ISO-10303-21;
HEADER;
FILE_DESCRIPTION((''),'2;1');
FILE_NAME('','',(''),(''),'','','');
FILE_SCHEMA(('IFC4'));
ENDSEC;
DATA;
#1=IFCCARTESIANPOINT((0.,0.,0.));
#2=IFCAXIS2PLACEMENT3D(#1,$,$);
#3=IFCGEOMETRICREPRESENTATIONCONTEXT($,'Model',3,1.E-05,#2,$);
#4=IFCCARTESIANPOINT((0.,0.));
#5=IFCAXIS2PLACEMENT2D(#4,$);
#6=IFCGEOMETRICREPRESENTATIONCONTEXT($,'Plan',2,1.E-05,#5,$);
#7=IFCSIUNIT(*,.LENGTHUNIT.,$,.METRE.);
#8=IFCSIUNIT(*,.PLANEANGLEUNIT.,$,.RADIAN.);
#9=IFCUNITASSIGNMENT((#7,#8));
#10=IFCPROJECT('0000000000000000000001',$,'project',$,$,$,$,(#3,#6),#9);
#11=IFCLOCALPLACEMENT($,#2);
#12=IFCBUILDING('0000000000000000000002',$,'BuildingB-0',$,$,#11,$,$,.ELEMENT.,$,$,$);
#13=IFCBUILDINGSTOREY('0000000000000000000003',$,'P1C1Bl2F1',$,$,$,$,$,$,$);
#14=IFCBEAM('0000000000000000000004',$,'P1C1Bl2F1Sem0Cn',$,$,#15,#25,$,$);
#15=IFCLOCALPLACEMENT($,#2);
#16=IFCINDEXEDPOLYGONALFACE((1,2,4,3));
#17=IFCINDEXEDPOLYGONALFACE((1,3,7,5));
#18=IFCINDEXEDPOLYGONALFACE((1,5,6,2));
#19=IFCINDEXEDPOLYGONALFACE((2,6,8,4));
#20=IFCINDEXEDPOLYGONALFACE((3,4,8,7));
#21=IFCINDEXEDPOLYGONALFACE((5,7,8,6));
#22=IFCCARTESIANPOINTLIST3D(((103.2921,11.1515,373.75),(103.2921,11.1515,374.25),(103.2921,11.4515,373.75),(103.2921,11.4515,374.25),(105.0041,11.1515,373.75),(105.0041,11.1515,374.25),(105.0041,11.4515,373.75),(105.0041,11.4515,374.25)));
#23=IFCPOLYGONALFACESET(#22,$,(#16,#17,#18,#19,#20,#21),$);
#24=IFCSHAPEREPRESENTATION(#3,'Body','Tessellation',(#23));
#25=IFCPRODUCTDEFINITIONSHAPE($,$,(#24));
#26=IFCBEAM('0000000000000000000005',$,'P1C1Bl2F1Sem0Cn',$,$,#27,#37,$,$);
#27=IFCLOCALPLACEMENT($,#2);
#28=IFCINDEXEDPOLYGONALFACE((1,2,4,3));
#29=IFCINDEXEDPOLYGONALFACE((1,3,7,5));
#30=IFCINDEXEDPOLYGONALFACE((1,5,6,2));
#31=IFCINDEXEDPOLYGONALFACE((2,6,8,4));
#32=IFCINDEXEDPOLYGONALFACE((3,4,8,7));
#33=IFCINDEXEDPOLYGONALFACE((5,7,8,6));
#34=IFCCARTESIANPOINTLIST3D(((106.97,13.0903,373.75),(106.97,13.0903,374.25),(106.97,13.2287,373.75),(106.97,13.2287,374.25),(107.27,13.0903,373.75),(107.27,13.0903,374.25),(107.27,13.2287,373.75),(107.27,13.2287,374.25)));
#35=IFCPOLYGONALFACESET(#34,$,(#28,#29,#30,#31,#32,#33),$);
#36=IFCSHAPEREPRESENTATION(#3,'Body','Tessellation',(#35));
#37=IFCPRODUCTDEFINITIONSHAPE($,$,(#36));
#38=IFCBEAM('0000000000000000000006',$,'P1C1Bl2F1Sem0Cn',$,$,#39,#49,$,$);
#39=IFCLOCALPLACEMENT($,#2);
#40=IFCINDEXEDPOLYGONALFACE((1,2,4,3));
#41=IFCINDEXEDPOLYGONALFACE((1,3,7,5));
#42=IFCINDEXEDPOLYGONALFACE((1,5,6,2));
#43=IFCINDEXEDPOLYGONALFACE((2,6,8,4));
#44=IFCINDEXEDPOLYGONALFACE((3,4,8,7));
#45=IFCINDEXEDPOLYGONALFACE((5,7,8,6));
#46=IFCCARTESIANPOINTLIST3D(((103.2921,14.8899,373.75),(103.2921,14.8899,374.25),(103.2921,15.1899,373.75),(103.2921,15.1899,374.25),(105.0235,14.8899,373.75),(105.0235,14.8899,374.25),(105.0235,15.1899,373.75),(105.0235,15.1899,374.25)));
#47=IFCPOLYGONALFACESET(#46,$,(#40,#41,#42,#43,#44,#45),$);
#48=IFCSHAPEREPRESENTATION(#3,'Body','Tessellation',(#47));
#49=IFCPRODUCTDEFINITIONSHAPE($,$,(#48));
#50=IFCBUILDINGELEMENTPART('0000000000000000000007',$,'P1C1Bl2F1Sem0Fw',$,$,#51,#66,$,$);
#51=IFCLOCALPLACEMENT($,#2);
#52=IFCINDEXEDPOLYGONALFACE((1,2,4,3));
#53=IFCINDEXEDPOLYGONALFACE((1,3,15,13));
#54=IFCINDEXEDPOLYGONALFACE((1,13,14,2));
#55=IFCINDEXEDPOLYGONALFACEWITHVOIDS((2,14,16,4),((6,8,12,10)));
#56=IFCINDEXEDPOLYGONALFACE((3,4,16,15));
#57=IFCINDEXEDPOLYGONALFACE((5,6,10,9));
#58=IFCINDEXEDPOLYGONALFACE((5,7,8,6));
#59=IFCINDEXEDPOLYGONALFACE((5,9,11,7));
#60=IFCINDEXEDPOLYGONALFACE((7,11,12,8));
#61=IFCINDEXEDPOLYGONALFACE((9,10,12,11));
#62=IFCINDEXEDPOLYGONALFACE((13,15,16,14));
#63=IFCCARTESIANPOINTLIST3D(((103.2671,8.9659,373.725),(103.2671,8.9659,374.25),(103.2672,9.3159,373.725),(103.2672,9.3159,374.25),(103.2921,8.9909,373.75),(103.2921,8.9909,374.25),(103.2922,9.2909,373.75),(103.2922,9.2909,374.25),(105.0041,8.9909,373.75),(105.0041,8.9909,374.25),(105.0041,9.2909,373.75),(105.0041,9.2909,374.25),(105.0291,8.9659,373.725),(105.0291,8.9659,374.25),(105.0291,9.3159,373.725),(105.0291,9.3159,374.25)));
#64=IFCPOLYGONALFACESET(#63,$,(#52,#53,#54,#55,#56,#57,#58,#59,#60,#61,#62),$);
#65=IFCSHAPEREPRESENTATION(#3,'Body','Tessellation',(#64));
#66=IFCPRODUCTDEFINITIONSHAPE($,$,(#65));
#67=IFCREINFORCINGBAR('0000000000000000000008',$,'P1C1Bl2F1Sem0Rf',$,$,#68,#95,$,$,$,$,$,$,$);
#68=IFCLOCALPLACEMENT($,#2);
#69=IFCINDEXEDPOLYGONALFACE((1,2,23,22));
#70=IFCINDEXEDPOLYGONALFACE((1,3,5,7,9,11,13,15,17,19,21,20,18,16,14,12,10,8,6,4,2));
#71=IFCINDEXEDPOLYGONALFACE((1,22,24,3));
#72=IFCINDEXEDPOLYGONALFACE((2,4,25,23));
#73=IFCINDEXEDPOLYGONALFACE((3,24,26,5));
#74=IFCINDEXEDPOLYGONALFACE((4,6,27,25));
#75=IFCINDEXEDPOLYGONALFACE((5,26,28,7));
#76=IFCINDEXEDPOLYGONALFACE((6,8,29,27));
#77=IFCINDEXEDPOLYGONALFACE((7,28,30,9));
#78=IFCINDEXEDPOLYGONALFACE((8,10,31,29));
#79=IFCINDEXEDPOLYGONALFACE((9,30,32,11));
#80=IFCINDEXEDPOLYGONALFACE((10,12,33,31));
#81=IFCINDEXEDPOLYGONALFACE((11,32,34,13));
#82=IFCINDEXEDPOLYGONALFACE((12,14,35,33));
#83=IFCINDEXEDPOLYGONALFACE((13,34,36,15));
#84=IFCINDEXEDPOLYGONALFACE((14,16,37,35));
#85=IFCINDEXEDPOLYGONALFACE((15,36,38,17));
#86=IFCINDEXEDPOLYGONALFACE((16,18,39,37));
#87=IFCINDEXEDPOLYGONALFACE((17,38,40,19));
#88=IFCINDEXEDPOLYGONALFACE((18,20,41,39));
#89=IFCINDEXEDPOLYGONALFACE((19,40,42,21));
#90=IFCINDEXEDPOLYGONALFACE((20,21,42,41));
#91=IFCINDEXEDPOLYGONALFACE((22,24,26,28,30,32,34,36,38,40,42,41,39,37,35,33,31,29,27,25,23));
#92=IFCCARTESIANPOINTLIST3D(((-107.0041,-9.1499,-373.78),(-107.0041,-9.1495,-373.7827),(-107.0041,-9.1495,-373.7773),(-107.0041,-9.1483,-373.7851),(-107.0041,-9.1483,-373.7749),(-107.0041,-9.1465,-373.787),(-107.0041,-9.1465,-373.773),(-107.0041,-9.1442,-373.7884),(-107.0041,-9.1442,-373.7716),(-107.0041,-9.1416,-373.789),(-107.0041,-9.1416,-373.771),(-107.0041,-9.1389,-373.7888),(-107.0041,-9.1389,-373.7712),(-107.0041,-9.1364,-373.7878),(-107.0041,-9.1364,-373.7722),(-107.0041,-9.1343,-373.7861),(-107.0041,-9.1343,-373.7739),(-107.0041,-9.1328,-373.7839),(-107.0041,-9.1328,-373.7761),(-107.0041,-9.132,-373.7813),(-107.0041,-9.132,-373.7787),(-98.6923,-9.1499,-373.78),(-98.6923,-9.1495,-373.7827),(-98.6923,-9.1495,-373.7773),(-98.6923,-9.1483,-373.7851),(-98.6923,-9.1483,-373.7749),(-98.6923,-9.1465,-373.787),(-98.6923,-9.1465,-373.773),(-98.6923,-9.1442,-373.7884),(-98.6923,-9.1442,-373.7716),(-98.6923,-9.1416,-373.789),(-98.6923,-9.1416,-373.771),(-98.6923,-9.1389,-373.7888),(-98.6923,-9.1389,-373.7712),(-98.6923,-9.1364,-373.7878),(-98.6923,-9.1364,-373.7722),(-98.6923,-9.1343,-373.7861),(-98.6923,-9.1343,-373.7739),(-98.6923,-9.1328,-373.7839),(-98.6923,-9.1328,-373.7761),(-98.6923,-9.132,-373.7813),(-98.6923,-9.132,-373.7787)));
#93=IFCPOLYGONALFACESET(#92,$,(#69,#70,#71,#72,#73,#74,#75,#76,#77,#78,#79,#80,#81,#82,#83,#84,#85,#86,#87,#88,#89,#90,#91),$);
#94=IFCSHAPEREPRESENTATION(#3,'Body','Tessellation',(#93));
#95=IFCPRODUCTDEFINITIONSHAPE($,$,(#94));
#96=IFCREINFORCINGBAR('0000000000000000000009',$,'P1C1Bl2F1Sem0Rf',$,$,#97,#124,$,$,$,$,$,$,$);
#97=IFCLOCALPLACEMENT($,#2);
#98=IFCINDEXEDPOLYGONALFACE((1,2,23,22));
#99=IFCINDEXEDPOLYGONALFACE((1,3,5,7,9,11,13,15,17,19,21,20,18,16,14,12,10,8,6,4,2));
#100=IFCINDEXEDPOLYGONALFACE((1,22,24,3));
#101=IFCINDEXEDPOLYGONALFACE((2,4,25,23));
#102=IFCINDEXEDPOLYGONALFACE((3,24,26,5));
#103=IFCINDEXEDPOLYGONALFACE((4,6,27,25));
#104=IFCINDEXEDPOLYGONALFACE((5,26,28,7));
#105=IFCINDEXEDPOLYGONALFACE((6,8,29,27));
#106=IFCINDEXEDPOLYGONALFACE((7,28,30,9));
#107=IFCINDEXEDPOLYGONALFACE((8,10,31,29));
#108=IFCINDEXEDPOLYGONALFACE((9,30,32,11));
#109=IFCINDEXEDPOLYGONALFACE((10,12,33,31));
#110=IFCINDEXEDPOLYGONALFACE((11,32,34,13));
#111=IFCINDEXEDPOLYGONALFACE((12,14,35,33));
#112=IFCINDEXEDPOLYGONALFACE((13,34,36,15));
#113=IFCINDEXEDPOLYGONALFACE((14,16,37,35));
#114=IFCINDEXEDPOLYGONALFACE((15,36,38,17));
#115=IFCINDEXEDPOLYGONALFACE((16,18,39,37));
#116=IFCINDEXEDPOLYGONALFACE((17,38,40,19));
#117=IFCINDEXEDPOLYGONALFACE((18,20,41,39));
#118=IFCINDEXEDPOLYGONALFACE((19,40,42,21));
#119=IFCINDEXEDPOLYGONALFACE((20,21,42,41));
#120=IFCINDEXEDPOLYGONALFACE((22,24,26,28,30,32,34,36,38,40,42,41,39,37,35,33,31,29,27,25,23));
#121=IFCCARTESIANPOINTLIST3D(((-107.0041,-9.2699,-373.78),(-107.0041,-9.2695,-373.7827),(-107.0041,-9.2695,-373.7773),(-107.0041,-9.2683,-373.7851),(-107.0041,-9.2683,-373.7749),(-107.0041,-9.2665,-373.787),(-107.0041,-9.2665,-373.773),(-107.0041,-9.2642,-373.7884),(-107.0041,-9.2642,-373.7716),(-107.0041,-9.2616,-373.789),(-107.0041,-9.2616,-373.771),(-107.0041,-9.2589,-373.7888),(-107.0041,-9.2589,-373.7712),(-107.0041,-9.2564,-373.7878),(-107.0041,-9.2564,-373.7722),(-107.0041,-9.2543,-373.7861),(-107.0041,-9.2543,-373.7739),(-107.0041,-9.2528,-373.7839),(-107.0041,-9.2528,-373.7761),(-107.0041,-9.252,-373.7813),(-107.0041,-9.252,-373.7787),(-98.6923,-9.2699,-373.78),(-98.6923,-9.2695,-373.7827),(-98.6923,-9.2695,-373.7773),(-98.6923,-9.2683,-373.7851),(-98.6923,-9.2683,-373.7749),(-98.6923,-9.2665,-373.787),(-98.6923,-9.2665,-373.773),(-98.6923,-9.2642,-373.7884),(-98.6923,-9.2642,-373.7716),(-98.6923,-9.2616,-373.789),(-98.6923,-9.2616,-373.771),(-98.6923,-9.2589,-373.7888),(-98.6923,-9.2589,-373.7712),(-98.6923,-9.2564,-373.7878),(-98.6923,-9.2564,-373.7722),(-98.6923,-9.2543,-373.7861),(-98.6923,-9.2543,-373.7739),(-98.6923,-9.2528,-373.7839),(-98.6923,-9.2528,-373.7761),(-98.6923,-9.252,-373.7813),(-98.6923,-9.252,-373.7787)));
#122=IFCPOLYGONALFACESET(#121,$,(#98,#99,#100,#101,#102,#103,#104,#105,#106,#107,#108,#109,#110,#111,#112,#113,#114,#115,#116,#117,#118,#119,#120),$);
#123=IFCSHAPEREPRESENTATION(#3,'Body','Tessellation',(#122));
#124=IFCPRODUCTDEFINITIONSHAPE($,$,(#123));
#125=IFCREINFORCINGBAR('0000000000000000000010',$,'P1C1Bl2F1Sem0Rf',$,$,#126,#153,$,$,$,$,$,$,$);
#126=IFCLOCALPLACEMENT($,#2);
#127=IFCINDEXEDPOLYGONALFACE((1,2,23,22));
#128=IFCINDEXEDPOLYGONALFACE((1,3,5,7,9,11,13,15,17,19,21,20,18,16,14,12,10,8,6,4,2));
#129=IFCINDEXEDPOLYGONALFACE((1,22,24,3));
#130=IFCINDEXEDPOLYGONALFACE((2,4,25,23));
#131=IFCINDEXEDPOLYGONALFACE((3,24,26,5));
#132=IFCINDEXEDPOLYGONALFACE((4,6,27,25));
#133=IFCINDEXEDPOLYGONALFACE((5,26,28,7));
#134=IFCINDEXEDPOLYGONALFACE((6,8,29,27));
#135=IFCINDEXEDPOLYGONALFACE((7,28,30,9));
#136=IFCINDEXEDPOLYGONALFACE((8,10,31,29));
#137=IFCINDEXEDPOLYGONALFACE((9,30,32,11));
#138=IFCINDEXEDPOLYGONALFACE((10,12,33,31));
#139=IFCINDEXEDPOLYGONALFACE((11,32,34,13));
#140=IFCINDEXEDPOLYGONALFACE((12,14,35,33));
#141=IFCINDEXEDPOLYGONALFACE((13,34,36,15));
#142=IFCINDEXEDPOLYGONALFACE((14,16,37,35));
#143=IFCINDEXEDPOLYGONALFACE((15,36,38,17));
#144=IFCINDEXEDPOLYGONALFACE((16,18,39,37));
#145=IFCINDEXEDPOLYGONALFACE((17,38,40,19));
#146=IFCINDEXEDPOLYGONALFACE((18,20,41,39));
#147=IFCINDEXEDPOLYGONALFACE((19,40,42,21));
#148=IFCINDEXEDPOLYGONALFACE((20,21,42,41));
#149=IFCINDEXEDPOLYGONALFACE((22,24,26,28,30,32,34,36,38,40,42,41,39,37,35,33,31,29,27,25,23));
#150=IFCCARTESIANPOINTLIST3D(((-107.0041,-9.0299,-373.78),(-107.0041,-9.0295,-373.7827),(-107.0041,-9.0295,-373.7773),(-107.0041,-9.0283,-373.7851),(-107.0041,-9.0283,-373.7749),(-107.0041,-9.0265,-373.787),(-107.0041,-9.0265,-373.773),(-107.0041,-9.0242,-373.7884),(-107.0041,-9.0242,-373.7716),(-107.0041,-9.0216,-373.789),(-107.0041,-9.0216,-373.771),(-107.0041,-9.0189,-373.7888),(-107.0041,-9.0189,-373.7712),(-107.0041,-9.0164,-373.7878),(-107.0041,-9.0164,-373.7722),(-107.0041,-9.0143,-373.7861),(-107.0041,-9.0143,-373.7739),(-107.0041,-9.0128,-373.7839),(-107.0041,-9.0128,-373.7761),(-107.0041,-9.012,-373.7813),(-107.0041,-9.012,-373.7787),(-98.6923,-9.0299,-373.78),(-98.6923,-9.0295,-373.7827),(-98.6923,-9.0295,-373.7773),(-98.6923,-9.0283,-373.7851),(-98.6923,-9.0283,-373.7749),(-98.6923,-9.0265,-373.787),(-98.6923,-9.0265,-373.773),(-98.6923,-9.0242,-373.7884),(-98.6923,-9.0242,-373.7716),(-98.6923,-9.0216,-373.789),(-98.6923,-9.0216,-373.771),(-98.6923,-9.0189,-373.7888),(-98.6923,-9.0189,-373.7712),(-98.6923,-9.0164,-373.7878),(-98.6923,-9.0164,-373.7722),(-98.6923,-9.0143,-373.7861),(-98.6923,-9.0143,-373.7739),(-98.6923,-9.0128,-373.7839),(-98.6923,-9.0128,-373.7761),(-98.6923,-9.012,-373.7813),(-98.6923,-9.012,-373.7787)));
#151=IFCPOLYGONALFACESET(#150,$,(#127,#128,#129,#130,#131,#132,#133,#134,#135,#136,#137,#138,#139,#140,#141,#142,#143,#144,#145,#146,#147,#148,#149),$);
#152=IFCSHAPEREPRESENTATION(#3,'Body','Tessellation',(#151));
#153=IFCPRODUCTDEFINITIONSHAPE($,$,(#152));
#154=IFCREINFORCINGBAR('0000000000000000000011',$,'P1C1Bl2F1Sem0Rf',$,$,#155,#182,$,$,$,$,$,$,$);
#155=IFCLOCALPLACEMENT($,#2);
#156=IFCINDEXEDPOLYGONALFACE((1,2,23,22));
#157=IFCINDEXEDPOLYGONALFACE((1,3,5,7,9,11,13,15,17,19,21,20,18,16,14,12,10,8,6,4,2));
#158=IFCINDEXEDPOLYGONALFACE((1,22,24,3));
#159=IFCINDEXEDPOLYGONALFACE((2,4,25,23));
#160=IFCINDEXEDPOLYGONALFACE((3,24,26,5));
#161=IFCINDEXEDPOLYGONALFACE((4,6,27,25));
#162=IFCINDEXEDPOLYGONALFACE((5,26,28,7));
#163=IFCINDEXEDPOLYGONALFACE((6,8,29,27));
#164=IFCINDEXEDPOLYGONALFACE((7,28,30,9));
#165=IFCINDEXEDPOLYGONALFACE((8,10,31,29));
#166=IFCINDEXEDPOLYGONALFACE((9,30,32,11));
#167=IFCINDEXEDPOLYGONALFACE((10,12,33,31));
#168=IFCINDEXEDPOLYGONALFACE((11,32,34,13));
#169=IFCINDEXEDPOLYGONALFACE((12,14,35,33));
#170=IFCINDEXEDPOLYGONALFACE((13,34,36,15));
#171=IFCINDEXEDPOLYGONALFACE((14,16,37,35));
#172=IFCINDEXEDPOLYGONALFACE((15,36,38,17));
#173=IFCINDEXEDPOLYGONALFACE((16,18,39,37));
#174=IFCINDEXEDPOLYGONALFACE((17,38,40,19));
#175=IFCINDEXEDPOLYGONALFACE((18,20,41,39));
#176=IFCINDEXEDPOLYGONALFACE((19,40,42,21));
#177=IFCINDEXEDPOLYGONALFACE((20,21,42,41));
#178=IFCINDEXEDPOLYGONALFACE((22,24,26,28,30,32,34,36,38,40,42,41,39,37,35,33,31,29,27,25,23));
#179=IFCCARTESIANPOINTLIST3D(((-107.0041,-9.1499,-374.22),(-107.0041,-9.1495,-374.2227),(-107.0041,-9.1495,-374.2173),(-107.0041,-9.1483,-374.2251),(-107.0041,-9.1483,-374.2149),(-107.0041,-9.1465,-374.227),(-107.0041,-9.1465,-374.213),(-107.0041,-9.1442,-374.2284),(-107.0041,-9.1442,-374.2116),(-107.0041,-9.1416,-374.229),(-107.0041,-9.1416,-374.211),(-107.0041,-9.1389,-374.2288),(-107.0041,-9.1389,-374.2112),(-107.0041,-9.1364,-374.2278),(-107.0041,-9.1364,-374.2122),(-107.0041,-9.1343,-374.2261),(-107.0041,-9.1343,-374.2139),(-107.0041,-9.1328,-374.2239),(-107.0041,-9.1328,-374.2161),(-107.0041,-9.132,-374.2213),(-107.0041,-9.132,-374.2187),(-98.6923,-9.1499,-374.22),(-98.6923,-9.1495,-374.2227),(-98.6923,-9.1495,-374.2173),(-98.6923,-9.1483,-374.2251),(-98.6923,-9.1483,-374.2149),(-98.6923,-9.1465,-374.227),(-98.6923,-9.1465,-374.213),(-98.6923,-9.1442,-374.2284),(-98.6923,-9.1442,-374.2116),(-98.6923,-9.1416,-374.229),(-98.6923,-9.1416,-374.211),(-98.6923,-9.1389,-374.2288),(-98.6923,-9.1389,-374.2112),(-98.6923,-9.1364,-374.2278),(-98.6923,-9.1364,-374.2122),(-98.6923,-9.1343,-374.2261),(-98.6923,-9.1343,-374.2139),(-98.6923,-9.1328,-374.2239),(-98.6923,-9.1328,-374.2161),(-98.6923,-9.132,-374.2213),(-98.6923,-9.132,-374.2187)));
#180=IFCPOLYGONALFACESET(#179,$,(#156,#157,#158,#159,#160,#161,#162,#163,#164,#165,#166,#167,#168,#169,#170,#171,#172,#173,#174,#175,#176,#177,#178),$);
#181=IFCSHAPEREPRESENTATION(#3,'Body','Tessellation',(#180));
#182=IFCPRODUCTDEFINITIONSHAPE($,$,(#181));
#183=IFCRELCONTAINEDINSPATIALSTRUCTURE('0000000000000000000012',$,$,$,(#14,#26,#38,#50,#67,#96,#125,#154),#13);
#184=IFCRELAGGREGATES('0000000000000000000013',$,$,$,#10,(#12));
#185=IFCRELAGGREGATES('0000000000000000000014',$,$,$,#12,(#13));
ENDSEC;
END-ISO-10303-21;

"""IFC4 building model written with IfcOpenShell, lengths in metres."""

from ifc_helpers import new_model, entity, si_unit, origin, origin_2d, place, context, project, spatial, polyline, outline, extrude, element, save


model = new_model("IFC4")

# Units and contexts
model_context = context("Model", 3, precision=1e-05, world=origin())
plan_context = context("Plan", 2, precision=1e-05, world=origin_2d())
ifc_project = project(units=[si_unit("LENGTHUNIT", "METRE"), si_unit("PLANEANGLEUNIT", "RADIAN")], contexts=[model_context, plan_context])

# Building, storey
building_placement = place(None, origin())
building = spatial("IfcBuilding", under=ifc_project, at=building_placement, Name="BuildingB-0", CompositionType="ELEMENT")
storey = spatial("IfcBuildingStorey", under=building, Name="P1C1Bl2F1")

# Beams
element("IfcBeam", 1, inside=storey, Name="P1C1Bl2F1Sem0Cn", context=model_context, shape_type="SweptSolid", body=[
    extrude(outline(polyline([(105.0041, 11.1515, 373.75), (105.0041, 11.4515, 373.75), (103.2921, 11.4515, 373.75), (103.2921, 11.1515, 373.75), (105.0041, 11.1515, 373.75)])), None, (0.0, 0.0, 1.0), 0.5),
])
element("IfcBeam", 2, inside=storey, Name="P1C1Bl2F1Sem0Cn", context=model_context, shape_type="SweptSolid", body=[
    extrude(outline(polyline([(107.27, 13.0903, 373.75), (107.27, 13.2287, 373.75), (106.97, 13.2287, 373.75), (106.97, 13.0903, 373.75), (107.27, 13.0903, 373.75)])), None, (0.0, 0.0, 1.0), 0.5),
])
element("IfcBeam", 3, inside=storey, Name="P1C1Bl2F1Sem0Cn", context=model_context, shape_type="SweptSolid", body=[
    extrude(outline(polyline([(105.0235, 14.8899, 373.75), (105.0235, 15.1899, 373.75), (103.2921, 15.1899, 373.75), (103.2921, 14.8899, 373.75), (105.0235, 14.8899, 373.75)])), None, (0.0, 0.0, 1.0), 0.5),
])

# Building element part, opening
building_element_part_1 = element("IfcBuildingElementPart", 4, inside=storey, Name="P1C1Bl2F1Sem0Fw", context=model_context, shape_type="SweptSolid", body=[
    extrude(outline(polyline([(105.0291, 8.9659, 373.725), (105.0291, 9.3159, 373.725), (103.2672, 9.3159, 373.725), (103.2671, 8.9659, 373.725), (105.0291, 8.9659, 373.725)])), None, (0.0, 0.0, 1.0), 0.525),
])
element("IfcOpeningElement", 5, inside=storey, cuts=building_element_part_1, context=model_context, shape_type="SweptSolid", body=[
    extrude(outline(polyline([(105.0041, 8.9909, 373.75), (105.0041, 9.2909, 373.75), (103.2922, 9.2909, 373.75), (103.2921, 8.9909, 373.75), (105.0041, 8.9909, 373.75)])), None, (0.0, 0.0, 1.0), 0.5),
])

# Reinforcing bars
element("IfcReinforcingBar", 6, inside=storey, Name="P1C1Bl2F1Sem0Rf", context=model_context, shape_type="SweptSolid", body=[
    entity("IfcSurfaceCurveSweptAreaSolid", entity("IfcCircleProfileDef", "AREA", None, None, 0.009), None, entity("IfcPolyline", [entity("IfcCartesianPoint", [107.0041, 9.1409, 373.78]), entity("IfcCartesianPoint", [98.6923, 9.1409, 373.78])]), None, None, entity("IfcPlane", entity("IfcAxis2Placement3D", entity("IfcCartesianPoint", [107.0041, 9.1409, 373.78]), entity("IfcDirection", [0.0, 0.0, 1.0]), entity("IfcDirection", [1.0, 0.0, 0.0])))),
])
element("IfcReinforcingBar", 7, inside=storey, Name="P1C1Bl2F1Sem0Rf", context=model_context, shape_type="SweptSolid", body=[
    entity("IfcSurfaceCurveSweptAreaSolid", entity("IfcCircleProfileDef", "AREA", None, None, 0.009), None, entity("IfcPolyline", [entity("IfcCartesianPoint", [107.0041, 9.2609, 373.78]), entity("IfcCartesianPoint", [98.6923, 9.2609, 373.78])]), None, None, entity("IfcPlane", entity("IfcAxis2Placement3D", entity("IfcCartesianPoint", [107.0041, 9.2609, 373.78]), entity("IfcDirection", [0.0, 0.0, 1.0]), entity("IfcDirection", [1.0, 0.0, 0.0])))),
])
element("IfcReinforcingBar", 8, inside=storey, Name="P1C1Bl2F1Sem0Rf", context=model_context, shape_type="SweptSolid", body=[
    entity("IfcSurfaceCurveSweptAreaSolid", entity("IfcCircleProfileDef", "AREA", None, None, 0.009), None, entity("IfcPolyline", [entity("IfcCartesianPoint", [107.0041, 9.0209, 373.78]), entity("IfcCartesianPoint", [98.6923, 9.0209, 373.78])]), None, None, entity("IfcPlane", entity("IfcAxis2Placement3D", entity("IfcCartesianPoint", [107.0041, 9.0209, 373.78]), entity("IfcDirection", [0.0, 0.0, 1.0]), entity("IfcDirection", [1.0, 0.0, 0.0])))),
])
element("IfcReinforcingBar", 9, inside=storey, Name="P1C1Bl2F1Sem0Rf", context=model_context, shape_type="SweptSolid", body=[
    entity("IfcSurfaceCurveSweptAreaSolid", entity("IfcCircleProfileDef", "AREA", None, None, 0.009), None, entity("IfcPolyline", [entity("IfcCartesianPoint", [107.0041, 9.1409, 374.22]), entity("IfcCartesianPoint", [98.6923, 9.1409, 374.22])]), None, None, entity("IfcPlane", entity("IfcAxis2Placement3D", entity("IfcCartesianPoint", [107.0041, 9.1409, 374.22]), entity("IfcDirection", [0.0, 0.0, 1.0]), entity("IfcDirection", [1.0, 0.0, 0.0])))),
])

save(model, "model.ifc")
